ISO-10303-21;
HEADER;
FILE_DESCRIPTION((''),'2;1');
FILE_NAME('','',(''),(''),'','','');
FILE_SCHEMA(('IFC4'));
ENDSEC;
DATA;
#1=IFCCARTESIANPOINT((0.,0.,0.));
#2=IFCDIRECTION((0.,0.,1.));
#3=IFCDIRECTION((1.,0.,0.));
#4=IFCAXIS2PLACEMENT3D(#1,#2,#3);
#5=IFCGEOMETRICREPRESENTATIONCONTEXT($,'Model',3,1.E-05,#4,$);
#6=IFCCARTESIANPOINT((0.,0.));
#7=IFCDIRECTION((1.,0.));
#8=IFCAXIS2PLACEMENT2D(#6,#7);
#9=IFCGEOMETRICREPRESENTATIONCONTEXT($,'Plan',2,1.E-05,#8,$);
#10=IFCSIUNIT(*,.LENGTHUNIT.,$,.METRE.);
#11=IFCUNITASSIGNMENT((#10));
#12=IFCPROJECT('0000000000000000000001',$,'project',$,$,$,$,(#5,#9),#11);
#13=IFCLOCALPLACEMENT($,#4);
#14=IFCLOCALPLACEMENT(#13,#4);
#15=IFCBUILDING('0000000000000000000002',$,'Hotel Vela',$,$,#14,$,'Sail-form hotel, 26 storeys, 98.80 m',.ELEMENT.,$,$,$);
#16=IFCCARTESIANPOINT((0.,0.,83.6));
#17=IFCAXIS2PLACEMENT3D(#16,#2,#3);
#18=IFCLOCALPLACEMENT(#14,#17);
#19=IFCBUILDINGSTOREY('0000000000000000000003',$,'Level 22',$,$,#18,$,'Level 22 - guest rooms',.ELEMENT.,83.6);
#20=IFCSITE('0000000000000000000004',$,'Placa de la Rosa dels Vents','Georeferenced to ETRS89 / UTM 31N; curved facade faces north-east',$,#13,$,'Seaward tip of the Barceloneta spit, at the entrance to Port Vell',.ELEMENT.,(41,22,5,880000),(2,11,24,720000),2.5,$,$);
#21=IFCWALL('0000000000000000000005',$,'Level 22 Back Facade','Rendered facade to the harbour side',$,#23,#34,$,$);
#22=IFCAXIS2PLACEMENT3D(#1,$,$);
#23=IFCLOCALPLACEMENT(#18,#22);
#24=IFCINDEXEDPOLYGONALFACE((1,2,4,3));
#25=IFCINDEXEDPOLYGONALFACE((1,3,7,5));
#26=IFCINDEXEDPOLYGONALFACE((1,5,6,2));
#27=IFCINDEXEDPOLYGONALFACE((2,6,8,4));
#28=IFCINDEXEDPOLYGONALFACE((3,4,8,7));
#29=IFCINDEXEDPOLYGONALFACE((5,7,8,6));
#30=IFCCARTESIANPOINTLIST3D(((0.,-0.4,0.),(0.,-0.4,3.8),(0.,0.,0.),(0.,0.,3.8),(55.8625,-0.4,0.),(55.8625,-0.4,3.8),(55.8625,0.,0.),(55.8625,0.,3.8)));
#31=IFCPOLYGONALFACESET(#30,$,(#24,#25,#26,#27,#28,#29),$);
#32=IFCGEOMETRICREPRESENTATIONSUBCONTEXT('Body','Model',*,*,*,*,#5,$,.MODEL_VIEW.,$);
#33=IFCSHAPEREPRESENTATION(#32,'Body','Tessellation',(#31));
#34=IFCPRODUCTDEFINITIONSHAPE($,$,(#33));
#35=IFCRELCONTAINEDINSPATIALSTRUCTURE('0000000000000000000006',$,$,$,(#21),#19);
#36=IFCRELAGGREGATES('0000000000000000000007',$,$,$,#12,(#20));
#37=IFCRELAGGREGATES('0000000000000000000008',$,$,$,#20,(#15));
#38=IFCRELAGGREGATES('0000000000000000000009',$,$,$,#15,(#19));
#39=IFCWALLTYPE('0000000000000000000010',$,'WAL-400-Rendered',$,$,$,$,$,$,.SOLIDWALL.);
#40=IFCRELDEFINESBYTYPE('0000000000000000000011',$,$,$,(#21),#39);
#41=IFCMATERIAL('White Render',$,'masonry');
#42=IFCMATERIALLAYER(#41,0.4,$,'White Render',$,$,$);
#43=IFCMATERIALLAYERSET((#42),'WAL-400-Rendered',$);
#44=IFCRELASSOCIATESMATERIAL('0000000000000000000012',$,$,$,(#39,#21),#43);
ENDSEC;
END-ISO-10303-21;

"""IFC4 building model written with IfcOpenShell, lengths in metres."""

from ifc_helpers import new_model, si_unit, frame, origin_with_axes, origin_2d_with_axis, place, context, subcontext, project, spatial, line, indexed_curve, outline, extrude, material, layer, layer_set, layer_usage, type_object, element, save


model = new_model("IFC4")

# Units and contexts
model_context = context("Model", 3, precision=1e-05, world=origin_with_axes())
plan_context = context("Plan", 2, precision=1e-05, world=origin_2d_with_axis())
body_context = subcontext(model_context, "Body", "Model", "MODEL_VIEW")
ifc_project = project(units=[si_unit("LENGTHUNIT", "METRE")], contexts=[model_context, plan_context])

# Site, building, storey
site_placement = place(None, origin_with_axes())
site = spatial("IfcSite", under=ifc_project, at=site_placement, Name="Placa de la Rosa dels Vents", Description="Georeferenced to ETRS89 / UTM 31N; curved facade faces north-east", LongName="Seaward tip of the Barceloneta spit, at the entrance to Port Vell", CompositionType="ELEMENT", RefLatitude=(41, 22, 5, 880000), RefLongitude=(2, 11, 24, 720000), RefElevation=2.5)
building_placement = place(site_placement, origin_with_axes())
building = spatial("IfcBuilding", under=site, at=building_placement, Name="Hotel Vela", LongName="Sail-form hotel, 26 storeys, 98.80 m", CompositionType="ELEMENT")
storey_placement = place(building_placement, frame((0.0, 0.0, 83.6), z_axis=(0.0, 0.0, 1.0), x_axis=(1.0, 0.0, 0.0)))
storey = spatial("IfcBuildingStorey", under=building, at=storey_placement, Name="Level 22", LongName="Level 22 - guest rooms", CompositionType="ELEMENT", Elevation=83.6)

# Wall
ifc_material_1 = material(Name="White Render", Category="masonry")
ifc_layer_1 = layer(ifc_material_1, 0.4, Name="White Render")
ifc_layer_set_1 = layer_set([ifc_layer_1], Name="WAL-400-Rendered")
ifc_layer_usage_1 = layer_usage(ifc_layer_set_1, "AXIS2", "POSITIVE", 0.0)
wall_type = type_object("IfcWallType", Name="WAL-400-Rendered", PredefinedType="SOLIDWALL", material=ifc_layer_set_1)
wall_placement = place(storey_placement, frame((0.0, -0.4, 0.0), z_axis=(0.0, 0.0, 1.0), x_axis=(1.0, 0.0, 0.0)))
element("IfcWall", 1, at=wall_placement, inside=storey, type_object=wall_type, material=ifc_layer_usage_1, Name="Level 22 Back Facade", Description="Rendered facade to the harbour side", context=body_context, shape_type="SweptSolid", body=[
    extrude(outline(indexed_curve([(0.0, 0.0), (55.8625, 0.0), (55.8625, 0.4), (0.0, 0.4)], segments=[line(1, 2, 3, 4, 1)])), origin_with_axes(), (0.0, 0.0, 1.0), 3.8),
])

save(model, "model.ifc")
